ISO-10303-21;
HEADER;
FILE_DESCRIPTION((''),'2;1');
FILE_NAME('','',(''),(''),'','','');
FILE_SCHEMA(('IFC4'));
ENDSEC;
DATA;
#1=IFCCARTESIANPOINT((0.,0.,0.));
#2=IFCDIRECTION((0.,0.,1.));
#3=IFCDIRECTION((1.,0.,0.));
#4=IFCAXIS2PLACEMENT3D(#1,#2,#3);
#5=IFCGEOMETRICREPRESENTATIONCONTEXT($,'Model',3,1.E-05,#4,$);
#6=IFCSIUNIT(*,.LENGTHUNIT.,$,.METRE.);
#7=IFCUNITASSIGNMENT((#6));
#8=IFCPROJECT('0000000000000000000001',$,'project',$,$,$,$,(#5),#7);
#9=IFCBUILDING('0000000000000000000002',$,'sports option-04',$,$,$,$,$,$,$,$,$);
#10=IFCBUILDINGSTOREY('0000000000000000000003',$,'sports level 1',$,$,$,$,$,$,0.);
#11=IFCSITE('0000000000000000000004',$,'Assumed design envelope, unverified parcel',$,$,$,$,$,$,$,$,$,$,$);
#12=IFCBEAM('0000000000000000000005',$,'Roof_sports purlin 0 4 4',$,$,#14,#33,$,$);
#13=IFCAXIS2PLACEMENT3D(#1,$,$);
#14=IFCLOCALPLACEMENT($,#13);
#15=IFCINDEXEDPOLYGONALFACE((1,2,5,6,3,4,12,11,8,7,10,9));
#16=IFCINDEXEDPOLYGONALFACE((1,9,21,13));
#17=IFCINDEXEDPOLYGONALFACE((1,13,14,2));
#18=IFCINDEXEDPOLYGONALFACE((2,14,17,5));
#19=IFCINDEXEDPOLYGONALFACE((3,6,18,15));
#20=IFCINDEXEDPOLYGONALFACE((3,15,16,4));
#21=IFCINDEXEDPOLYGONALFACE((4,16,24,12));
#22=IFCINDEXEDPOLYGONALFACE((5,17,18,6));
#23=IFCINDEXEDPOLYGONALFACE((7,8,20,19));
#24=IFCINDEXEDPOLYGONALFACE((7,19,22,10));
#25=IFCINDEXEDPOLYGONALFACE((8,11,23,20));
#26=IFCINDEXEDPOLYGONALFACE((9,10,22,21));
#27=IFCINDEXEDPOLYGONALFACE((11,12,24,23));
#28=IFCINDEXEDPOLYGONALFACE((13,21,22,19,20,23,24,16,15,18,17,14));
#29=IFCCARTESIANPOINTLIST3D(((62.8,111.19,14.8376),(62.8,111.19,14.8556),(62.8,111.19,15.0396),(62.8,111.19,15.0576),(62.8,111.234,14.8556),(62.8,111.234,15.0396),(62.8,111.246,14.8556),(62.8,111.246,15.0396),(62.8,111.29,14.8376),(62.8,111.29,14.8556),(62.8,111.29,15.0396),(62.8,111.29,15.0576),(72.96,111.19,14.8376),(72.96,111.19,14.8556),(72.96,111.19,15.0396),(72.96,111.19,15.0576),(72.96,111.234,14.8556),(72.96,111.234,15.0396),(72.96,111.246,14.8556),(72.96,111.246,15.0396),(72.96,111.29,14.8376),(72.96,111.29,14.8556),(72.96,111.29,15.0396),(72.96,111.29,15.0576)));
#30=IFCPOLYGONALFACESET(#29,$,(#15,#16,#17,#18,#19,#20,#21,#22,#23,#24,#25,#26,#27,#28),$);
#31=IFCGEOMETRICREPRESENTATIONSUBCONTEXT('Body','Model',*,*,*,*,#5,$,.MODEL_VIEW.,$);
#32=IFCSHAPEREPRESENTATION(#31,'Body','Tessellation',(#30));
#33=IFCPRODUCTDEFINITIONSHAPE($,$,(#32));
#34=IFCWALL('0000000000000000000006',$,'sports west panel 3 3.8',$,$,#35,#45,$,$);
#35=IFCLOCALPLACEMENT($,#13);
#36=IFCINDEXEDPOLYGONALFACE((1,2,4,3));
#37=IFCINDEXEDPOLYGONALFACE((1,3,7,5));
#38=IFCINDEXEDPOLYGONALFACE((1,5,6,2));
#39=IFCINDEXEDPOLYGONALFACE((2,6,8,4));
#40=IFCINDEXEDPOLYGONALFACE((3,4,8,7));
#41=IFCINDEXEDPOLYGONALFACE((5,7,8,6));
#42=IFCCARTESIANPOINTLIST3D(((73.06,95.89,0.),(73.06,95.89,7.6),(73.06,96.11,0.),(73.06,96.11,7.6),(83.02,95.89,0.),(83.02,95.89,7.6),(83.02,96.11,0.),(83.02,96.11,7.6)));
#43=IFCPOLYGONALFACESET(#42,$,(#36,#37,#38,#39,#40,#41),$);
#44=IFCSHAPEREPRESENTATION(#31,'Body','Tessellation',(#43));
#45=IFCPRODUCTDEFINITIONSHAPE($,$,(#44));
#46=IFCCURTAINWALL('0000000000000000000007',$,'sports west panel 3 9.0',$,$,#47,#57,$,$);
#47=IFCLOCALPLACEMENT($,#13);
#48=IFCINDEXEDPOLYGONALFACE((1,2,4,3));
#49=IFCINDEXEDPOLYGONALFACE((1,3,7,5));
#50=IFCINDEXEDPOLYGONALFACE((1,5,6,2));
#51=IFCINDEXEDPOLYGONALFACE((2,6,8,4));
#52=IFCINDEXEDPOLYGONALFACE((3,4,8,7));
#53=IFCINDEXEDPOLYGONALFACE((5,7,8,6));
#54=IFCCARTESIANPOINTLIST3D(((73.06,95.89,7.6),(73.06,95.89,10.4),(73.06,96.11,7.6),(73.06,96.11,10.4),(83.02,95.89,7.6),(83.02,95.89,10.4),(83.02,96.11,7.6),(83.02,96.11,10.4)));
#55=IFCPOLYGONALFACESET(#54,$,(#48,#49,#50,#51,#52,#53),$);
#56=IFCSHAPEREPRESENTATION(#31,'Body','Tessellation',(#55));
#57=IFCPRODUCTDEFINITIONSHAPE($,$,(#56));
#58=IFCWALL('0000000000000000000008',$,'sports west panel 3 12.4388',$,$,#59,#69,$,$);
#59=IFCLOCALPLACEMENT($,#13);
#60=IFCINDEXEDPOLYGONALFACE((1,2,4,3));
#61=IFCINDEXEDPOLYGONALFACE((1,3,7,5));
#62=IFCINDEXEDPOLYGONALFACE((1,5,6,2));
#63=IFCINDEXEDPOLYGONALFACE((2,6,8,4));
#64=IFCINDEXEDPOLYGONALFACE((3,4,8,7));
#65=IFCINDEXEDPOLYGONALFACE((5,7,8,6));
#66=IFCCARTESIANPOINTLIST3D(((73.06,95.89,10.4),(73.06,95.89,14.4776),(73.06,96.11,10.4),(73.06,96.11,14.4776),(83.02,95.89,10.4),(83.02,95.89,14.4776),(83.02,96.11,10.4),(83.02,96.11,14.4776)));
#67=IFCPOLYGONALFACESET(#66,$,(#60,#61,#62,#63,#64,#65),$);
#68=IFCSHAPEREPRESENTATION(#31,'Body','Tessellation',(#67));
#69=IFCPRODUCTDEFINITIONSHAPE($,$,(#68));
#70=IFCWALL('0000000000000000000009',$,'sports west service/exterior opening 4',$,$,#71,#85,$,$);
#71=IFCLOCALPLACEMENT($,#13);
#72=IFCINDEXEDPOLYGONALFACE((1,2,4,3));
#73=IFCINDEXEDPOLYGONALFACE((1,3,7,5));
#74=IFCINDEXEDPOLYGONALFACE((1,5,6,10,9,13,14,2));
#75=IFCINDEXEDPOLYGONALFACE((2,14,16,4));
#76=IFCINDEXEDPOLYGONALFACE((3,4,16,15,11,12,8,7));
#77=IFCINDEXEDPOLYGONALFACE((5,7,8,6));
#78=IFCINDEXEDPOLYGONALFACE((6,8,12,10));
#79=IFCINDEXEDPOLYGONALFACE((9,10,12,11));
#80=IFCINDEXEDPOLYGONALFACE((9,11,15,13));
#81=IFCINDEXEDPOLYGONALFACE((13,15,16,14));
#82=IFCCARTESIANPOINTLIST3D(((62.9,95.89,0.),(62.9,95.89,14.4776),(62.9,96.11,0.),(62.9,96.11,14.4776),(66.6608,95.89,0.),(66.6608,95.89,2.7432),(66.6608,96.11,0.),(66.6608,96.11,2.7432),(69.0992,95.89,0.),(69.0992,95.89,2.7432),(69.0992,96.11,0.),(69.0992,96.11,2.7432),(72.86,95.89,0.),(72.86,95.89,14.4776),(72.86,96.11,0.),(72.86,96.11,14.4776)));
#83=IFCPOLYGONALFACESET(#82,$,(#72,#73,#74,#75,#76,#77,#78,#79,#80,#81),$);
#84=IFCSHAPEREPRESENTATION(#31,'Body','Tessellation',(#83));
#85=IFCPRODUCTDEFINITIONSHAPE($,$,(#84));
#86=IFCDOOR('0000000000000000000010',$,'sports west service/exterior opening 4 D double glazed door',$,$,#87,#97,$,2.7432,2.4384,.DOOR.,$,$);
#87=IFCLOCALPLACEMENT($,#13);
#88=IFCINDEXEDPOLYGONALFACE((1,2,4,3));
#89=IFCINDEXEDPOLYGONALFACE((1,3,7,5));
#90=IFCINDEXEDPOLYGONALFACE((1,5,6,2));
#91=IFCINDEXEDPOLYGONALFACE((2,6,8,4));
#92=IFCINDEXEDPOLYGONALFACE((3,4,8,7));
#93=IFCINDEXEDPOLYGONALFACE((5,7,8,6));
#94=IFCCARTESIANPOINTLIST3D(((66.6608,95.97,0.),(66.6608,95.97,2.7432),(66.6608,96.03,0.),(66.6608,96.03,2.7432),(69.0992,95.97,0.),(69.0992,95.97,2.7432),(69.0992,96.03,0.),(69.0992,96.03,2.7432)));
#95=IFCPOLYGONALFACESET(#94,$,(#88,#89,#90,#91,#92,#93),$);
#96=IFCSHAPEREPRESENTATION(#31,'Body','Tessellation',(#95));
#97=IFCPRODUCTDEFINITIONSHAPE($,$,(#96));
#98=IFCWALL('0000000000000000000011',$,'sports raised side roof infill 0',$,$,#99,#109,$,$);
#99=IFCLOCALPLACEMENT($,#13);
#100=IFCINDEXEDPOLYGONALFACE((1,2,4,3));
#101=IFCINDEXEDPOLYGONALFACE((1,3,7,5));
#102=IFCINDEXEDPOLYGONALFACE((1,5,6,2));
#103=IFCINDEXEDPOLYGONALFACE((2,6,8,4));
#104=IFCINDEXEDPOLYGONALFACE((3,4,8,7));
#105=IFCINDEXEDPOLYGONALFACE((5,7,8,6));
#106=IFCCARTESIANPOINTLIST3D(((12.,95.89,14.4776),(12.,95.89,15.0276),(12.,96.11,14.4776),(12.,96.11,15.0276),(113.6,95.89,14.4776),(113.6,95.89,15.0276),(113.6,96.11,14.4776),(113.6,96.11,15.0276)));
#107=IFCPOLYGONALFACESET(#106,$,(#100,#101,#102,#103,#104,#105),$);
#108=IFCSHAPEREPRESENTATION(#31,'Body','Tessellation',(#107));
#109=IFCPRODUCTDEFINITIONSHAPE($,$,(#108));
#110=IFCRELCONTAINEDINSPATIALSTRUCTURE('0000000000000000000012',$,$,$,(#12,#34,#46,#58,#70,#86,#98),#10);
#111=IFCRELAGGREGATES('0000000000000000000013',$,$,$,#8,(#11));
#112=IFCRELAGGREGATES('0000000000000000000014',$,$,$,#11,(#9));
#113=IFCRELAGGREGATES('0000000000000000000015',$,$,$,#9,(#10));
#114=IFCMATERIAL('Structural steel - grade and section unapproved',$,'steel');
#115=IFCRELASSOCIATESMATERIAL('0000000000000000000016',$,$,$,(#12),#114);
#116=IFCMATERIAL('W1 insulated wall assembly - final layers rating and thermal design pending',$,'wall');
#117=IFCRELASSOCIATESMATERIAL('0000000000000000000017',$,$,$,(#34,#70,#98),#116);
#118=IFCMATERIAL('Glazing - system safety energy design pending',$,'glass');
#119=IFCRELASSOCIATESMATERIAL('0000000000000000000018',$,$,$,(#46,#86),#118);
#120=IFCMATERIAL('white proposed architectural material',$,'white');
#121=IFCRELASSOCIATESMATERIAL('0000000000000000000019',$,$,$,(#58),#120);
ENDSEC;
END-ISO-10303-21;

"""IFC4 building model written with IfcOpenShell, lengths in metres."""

from ifc_helpers import new_model, si_unit, frame, origin_with_axes, place, context, subcontext, project, spatial, rectangle, i_section, extrude, material, element, fill, save


model = new_model("IFC4")

# Units and contexts
model_context = context("Model", 3, precision=1e-05, world=origin_with_axes())
body_context = subcontext(model_context, "Body", "Model", "MODEL_VIEW")
ifc_project = project(units=[si_unit("LENGTHUNIT", "METRE")], contexts=[model_context])

# Site, building, storey
site = spatial("IfcSite", under=ifc_project, Name="Assumed design envelope, unverified parcel")
building = spatial("IfcBuilding", under=site, Name="sports option-04")
storey = spatial("IfcBuildingStorey", under=building, Name="sports level 1", Elevation=0.0)

# Shared definitions
ifc_material_1 = material(Name="Structural steel - grade and section unapproved", Category="steel")

# Beam
for number, where, z_axis, x_axis, name in (
    (1, (72.96, 111.24, 14.9476), (-1.0, 0.0, 0.0), (0.0, -1.0, 0.0), "Roof_sports purlin 0 4 4"),
):
    element("IfcBeam", number, at=place(None, frame(where, z_axis=z_axis, x_axis=x_axis)), inside=storey, material=ifc_material_1, Name=name, context=body_context, shape_type="SweptSolid", body=[
        extrude(i_section(OverallWidth=0.1, OverallDepth=0.22, WebThickness=0.012, FlangeThickness=0.018, FilletRadius=0.0), origin_with_axes(), (0.0, 0.0, 1.0), 10.16),
    ])

# Wall
ifc_material_2 = material(Name="W1 insulated wall assembly - final layers rating and thermal design pending", Category="wall")
wall_1_placement = place(None, frame((78.04, 96.0, 0.0), z_axis=(0.0, 0.0, 1.0), x_axis=(0.0, 1.0, 0.0)))
element("IfcWall", 2, at=wall_1_placement, inside=storey, material=ifc_material_2, Name="sports west panel 3 3.8", context=body_context, shape_type="SweptSolid", body=[
    extrude(rectangle(XDim=0.22, YDim=9.96), origin_with_axes(), (0.0, 0.0, 1.0), 7.6),
])

# Curtain wall
ifc_material_3 = material(Name="Glazing - system safety energy design pending", Category="glass")
curtain_wall_placement = place(None, frame((78.04, 96.0, 7.6), z_axis=(0.0, 0.0, 1.0), x_axis=(0.0, 1.0, 0.0)))
element("IfcCurtainWall", 3, at=curtain_wall_placement, inside=storey, material=ifc_material_3, Name="sports west panel 3 9.0", context=body_context, shape_type="SweptSolid", body=[
    extrude(rectangle(XDim=0.22, YDim=9.96), origin_with_axes(), (0.0, 0.0, 1.0), 2.8),
])

# Wall
ifc_material_4 = material(Name="white proposed architectural material", Category="white")
wall_2_placement = place(None, frame((78.04, 96.0, 10.4), z_axis=(0.0, 0.0, 1.0), x_axis=(0.0, 1.0, 0.0)))
element("IfcWall", 4, at=wall_2_placement, inside=storey, material=ifc_material_4, Name="sports west panel 3 12.4388", context=body_context, shape_type="SweptSolid", body=[
    extrude(rectangle(XDim=0.22, YDim=9.96), origin_with_axes(), (0.0, 0.0, 1.0), 4.0776),
])

# Wall, opening, door
wall_3_placement = place(None, frame((67.88, 96.0, 0.0), z_axis=(0.0, 0.0, 1.0), x_axis=(-1.0, 0.0, 0.0)))
wall_3 = element("IfcWall", 5, at=wall_3_placement, inside=storey, material=ifc_material_2, Name="sports west service/exterior opening 4", context=body_context, shape_type="SweptSolid", body=[
    extrude(rectangle(XDim=9.96, YDim=0.22), origin_with_axes(), (0.0, 0.0, 1.0), 14.4776),
])
opening_placement = place(None, frame((67.88, 96.0, 0.0), z_axis=(0.0, 0.0, 1.0), x_axis=(-1.0, 0.0, 0.0)))
opening = element("IfcOpeningElement", 6, at=opening_placement, cuts=wall_3, context=body_context, shape_type="SweptSolid", body=[
    extrude(rectangle(XDim=2.4384, YDim=0.32), origin_with_axes(), (0.0, 0.0, 1.0), 2.7432),
])
door_placement = place(None, frame((67.88, 96.0, 0.0), z_axis=(0.0, 0.0, 1.0), x_axis=(-1.0, 0.0, 0.0)))
door = element("IfcDoor", 7, at=door_placement, inside=storey, material=ifc_material_3, Name="sports west service/exterior opening 4 D double glazed door", OverallHeight=2.7432, OverallWidth=2.4384, PredefinedType="DOOR", context=body_context, shape_type="SweptSolid", body=[
    extrude(rectangle(XDim=2.4384, YDim=0.06), origin_with_axes(), (0.0, 0.0, 1.0), 2.7432),
])
fill(opening, door)

# Wall
wall_4_placement = place(None, frame((62.8, 96.0, 14.4776), z_axis=(0.0, 0.0, 1.0), x_axis=(0.0, 1.0, 0.0)))
element("IfcWall", 8, at=wall_4_placement, inside=storey, material=ifc_material_2, Name="sports raised side roof infill 0", context=body_context, shape_type="SweptSolid", body=[
    extrude(rectangle(XDim=0.22, YDim=101.6), origin_with_axes(), (0.0, 0.0, 1.0), 0.55),
])

save(model, "model.ifc")
